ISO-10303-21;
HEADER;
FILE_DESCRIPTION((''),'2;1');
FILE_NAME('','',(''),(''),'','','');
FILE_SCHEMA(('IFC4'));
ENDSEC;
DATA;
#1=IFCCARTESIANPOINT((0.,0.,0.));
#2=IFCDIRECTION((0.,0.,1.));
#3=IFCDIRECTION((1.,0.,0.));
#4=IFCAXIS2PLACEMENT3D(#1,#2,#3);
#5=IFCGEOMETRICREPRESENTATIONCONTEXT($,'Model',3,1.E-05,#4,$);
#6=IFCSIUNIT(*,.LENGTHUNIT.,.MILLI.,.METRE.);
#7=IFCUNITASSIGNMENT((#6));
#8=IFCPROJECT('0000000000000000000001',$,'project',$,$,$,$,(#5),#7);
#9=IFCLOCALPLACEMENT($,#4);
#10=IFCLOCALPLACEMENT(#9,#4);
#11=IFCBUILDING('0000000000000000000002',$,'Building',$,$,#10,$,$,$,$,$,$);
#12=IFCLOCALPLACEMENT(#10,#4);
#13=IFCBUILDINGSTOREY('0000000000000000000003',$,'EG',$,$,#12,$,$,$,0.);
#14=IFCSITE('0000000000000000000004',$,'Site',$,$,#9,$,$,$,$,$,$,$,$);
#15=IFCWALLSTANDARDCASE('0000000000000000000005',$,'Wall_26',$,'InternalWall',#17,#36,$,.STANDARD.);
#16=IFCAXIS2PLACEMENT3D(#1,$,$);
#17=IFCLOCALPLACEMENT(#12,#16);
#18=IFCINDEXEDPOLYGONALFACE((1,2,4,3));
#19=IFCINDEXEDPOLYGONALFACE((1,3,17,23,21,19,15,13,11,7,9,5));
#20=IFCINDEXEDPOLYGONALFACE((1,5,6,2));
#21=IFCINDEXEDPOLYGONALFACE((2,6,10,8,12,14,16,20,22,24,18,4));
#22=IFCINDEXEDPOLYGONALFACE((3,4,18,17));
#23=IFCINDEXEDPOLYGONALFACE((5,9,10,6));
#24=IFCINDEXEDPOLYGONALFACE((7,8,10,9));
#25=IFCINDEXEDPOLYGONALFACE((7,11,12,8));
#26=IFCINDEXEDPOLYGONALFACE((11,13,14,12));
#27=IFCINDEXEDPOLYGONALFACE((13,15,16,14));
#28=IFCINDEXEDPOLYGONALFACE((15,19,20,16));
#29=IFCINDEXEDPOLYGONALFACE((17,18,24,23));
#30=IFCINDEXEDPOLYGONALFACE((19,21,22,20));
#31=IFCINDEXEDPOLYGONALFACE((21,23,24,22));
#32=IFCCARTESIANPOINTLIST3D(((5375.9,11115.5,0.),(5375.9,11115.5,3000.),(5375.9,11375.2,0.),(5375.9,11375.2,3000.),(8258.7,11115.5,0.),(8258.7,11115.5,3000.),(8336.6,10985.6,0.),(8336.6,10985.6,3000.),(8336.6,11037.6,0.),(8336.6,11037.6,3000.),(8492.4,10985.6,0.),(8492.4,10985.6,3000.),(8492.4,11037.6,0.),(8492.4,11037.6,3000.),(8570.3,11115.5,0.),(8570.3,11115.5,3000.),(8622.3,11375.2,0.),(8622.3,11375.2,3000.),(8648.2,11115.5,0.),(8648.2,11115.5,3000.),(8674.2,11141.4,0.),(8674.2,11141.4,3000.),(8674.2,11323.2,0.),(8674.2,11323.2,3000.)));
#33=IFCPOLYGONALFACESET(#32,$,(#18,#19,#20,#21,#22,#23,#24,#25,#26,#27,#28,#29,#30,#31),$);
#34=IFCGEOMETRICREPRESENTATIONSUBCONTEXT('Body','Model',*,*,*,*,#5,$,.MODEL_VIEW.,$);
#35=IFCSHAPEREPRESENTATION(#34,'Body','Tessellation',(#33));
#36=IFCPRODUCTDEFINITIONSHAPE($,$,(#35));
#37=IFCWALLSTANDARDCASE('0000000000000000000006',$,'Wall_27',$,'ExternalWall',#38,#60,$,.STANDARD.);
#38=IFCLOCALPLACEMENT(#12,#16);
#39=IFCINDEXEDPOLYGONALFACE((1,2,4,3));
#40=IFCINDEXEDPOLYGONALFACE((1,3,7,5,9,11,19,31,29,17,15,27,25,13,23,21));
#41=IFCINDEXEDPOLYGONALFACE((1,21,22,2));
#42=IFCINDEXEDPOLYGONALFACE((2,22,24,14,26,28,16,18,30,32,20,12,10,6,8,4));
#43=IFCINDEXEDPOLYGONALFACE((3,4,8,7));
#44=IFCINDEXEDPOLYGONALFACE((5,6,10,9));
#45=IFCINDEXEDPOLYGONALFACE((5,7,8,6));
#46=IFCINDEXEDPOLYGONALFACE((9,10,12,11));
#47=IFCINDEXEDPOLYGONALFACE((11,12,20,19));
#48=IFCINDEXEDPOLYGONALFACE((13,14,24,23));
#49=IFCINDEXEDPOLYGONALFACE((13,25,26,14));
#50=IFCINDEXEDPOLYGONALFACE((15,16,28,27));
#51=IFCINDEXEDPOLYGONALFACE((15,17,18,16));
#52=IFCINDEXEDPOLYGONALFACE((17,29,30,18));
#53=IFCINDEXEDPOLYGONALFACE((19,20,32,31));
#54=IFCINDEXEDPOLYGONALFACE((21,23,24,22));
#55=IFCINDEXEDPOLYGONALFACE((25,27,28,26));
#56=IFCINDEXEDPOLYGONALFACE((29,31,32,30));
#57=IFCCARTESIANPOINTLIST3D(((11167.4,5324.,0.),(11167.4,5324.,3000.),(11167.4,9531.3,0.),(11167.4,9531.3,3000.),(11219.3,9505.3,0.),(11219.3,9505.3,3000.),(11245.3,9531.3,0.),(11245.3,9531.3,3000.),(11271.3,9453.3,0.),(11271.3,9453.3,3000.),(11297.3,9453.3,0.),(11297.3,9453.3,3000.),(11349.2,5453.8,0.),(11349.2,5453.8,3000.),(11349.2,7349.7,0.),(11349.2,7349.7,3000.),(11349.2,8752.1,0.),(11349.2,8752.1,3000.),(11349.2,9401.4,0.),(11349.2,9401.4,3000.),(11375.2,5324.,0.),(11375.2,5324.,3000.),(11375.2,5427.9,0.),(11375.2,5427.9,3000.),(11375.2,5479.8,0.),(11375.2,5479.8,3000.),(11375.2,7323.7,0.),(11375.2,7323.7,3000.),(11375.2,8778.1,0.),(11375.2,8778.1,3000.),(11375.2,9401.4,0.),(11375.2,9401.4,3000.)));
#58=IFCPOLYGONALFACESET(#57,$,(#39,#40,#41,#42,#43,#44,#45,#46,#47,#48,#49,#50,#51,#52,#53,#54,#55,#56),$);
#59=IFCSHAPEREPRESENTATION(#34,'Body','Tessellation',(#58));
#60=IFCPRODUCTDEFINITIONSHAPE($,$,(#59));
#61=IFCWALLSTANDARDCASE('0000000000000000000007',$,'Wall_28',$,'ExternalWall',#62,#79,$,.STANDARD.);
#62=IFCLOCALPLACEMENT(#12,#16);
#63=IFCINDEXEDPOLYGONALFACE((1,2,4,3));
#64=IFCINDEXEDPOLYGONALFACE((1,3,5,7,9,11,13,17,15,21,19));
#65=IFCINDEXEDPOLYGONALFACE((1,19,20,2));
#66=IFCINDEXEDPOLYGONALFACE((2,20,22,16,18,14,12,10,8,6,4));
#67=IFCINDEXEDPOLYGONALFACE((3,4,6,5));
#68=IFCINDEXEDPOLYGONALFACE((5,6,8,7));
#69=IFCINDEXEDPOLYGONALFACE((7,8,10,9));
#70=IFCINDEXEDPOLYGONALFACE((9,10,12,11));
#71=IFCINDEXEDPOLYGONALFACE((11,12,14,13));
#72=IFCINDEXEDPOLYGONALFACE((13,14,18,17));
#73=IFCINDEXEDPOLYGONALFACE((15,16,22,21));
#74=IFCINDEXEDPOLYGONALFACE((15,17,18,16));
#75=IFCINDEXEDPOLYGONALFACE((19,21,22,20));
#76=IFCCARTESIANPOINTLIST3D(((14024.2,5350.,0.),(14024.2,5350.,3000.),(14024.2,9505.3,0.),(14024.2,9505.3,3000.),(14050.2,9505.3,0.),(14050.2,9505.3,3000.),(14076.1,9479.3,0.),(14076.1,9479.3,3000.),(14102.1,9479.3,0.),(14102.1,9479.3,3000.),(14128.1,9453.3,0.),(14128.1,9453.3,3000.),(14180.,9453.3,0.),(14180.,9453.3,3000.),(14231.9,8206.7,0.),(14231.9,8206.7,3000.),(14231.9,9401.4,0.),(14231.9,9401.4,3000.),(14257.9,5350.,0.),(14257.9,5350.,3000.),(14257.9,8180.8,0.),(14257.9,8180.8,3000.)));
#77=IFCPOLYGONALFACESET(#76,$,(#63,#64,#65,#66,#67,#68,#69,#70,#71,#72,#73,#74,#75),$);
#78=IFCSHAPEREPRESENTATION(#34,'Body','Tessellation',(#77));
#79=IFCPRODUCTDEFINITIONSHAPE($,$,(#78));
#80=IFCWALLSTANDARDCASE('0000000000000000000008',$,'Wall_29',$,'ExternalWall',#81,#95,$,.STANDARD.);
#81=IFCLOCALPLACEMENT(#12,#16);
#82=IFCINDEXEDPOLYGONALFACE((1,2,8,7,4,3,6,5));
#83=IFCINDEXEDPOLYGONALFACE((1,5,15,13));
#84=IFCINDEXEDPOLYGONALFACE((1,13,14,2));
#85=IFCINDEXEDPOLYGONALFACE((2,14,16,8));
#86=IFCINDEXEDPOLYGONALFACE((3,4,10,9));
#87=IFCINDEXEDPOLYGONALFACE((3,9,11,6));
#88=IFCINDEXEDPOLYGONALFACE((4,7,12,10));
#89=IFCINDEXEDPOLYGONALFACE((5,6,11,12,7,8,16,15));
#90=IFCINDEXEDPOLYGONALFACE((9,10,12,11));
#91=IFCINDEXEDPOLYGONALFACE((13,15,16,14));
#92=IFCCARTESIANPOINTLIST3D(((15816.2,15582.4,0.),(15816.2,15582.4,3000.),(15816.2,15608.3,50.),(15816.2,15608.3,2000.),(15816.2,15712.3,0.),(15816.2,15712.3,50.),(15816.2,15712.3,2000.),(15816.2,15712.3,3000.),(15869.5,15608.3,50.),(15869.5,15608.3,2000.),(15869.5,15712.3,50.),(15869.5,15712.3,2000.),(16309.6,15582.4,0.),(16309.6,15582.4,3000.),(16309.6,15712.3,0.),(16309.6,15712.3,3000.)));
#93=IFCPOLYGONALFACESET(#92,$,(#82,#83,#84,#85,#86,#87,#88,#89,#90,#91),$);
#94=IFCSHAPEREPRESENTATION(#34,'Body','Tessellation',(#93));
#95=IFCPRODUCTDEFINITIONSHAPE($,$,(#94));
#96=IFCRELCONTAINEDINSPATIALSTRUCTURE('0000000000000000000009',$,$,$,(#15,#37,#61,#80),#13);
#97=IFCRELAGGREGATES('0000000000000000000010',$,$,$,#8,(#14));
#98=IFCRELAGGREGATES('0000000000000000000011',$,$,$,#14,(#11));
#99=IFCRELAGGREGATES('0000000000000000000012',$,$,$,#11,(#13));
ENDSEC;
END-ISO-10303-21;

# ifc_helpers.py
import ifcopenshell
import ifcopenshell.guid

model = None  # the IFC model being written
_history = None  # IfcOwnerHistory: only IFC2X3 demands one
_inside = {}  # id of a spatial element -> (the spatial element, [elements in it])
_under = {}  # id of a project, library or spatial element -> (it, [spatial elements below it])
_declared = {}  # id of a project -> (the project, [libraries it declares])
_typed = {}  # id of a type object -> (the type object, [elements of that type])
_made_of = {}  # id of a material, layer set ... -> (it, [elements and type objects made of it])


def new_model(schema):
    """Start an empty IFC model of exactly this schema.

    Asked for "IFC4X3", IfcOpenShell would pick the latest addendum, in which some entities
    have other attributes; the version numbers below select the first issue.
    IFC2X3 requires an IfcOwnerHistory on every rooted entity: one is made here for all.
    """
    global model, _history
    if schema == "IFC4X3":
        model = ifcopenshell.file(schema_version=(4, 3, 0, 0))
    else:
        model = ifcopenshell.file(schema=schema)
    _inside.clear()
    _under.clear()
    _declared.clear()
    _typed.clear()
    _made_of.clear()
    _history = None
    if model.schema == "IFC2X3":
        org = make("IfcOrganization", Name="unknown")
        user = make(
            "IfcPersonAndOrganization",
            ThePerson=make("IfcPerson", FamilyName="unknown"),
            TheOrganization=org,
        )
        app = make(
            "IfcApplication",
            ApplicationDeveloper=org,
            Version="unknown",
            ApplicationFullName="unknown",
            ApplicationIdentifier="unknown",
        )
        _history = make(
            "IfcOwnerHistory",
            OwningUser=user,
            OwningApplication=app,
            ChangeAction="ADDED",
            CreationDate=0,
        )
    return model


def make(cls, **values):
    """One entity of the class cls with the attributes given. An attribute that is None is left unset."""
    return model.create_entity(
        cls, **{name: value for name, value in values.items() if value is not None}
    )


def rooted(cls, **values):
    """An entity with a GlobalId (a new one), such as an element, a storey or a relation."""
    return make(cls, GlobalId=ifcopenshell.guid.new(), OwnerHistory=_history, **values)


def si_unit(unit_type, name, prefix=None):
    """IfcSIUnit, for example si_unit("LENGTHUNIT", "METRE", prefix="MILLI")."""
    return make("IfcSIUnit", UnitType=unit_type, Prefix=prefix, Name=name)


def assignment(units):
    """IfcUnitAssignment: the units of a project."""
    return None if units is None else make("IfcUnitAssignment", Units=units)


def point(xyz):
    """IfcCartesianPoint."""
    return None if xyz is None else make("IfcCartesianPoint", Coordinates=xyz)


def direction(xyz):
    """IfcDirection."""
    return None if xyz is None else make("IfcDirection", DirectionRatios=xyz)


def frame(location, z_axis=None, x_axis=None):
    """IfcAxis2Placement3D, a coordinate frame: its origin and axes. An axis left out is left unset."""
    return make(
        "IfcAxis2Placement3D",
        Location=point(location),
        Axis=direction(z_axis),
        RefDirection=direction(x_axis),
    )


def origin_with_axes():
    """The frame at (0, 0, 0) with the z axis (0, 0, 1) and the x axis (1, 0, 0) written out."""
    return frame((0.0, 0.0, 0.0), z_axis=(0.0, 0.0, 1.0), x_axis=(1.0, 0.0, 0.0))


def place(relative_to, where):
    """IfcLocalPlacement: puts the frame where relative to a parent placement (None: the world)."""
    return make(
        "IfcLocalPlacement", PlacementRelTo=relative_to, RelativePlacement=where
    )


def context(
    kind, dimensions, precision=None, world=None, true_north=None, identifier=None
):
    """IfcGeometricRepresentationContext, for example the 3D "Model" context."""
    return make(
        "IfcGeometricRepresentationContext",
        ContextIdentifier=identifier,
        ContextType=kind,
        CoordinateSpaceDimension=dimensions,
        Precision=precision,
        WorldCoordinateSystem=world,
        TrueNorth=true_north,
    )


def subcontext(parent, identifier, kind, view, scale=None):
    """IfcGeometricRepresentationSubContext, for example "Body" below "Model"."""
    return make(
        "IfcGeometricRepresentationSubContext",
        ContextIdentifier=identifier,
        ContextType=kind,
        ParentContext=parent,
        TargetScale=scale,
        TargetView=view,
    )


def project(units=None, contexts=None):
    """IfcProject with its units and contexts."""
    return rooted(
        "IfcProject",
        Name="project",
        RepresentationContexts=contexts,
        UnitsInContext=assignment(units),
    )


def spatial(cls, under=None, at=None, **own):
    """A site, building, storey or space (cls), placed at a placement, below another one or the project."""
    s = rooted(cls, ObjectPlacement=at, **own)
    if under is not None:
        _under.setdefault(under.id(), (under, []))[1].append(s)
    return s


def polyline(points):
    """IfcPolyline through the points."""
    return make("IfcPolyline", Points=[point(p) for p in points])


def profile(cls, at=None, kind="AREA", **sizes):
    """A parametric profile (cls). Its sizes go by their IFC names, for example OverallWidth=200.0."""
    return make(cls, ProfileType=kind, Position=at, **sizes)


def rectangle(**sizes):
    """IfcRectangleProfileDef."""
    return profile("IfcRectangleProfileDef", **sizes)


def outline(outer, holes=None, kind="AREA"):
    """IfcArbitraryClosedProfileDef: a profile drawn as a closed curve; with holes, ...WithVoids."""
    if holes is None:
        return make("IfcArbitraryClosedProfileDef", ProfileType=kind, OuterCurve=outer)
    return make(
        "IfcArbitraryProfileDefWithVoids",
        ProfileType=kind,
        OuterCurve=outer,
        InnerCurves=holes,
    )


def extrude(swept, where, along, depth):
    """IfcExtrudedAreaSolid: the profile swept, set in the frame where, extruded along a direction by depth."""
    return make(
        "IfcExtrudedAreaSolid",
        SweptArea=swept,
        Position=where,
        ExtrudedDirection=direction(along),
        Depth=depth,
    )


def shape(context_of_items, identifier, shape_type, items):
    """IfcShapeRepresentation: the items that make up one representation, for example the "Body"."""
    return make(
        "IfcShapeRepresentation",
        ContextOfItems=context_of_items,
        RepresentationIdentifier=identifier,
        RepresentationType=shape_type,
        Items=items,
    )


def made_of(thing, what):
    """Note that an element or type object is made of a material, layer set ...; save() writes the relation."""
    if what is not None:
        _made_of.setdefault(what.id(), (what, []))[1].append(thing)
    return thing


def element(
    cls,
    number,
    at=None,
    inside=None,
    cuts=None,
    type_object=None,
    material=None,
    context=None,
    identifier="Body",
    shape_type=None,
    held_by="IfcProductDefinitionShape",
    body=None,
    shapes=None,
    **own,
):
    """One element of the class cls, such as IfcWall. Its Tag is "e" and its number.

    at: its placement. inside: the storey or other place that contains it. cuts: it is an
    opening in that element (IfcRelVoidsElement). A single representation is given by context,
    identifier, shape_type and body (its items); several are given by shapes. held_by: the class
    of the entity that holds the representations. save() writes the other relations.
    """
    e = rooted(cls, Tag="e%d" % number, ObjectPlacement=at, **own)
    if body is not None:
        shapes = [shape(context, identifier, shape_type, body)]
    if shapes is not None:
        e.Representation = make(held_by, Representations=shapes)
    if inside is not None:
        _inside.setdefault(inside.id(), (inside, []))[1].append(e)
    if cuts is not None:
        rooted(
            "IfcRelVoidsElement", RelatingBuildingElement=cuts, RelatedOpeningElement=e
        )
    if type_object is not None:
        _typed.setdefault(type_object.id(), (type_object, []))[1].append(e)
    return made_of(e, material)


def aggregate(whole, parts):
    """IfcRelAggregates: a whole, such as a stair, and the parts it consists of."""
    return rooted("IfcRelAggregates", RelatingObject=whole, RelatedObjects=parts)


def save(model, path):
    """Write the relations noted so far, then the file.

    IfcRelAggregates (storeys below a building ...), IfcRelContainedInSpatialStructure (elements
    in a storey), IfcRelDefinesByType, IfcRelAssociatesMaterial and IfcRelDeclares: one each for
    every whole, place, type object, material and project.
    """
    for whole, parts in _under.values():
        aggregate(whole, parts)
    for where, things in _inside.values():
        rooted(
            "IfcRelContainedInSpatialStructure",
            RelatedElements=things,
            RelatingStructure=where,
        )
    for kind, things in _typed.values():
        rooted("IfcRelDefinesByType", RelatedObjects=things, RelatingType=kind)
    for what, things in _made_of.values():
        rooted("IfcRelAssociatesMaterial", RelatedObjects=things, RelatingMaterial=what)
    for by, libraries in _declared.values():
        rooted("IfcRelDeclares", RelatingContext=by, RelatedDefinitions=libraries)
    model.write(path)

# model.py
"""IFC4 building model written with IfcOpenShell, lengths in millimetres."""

from ifc_helpers import new_model, si_unit, frame, origin_with_axes, place, context, subcontext, project, spatial, polyline, rectangle, outline, extrude, element, save


model = new_model("IFC4")

# Units and contexts
model_context = context("Model", 3, precision=1e-05, world=origin_with_axes())
body_context = subcontext(model_context, "Body", "Model", "MODEL_VIEW")
ifc_project = project(units=[si_unit("LENGTHUNIT", "METRE", prefix="MILLI")], contexts=[model_context])

# Site, building, storey
site_placement = place(None, origin_with_axes())
site = spatial("IfcSite", under=ifc_project, at=site_placement, Name="Site")
building_placement = place(site_placement, origin_with_axes())
building = spatial("IfcBuilding", under=site, at=building_placement, Name="Building")
storey_placement = place(building_placement, origin_with_axes())
storey = spatial("IfcBuildingStorey", under=building, at=storey_placement, Name="EG", Elevation=0.0)

# Walls
wall_1_placement = place(storey_placement, origin_with_axes())
element("IfcWallStandardCase", 1, at=wall_1_placement, inside=storey, Name="Wall_26", ObjectType="InternalWall", PredefinedType="STANDARD", context=body_context, shape_type="SweptSolid", body=[
    extrude(outline(polyline([(8336.6, 10985.6, 0.0), (8336.6, 11037.6, 0.0), (8258.7, 11115.5, 0.0), (5375.9, 11115.5, 0.0), (5375.9, 11375.2, 0.0), (8622.3, 11375.2, 0.0), (8674.2, 11323.2, 0.0), (8674.2, 11141.4, 0.0), (8648.2, 11115.5, 0.0), (8570.3, 11115.5, 0.0), (8492.4, 11037.6, 0.0), (8492.4, 10985.6, 0.0), (8336.6, 10985.6, 0.0)])), origin_with_axes(), (0.0, 0.0, 1.0), 3000.0),
])
wall_2_placement = place(storey_placement, origin_with_axes())
element("IfcWallStandardCase", 2, at=wall_2_placement, inside=storey, Name="Wall_27", ObjectType="ExternalWall", PredefinedType="STANDARD", context=body_context, shape_type="SweptSolid", body=[
    extrude(outline(polyline([(11167.4, 5324.0, 0.0), (11167.4, 9531.3, 0.0), (11245.3, 9531.3, 0.0), (11219.3, 9505.3, 0.0), (11271.3, 9453.3, 0.0), (11297.3, 9453.3, 0.0), (11349.2, 9401.4, 0.0), (11375.2, 9401.4, 0.0), (11375.2, 8778.1, 0.0), (11349.2, 8752.1, 0.0), (11349.2, 7349.7, 0.0), (11375.2, 7323.7, 0.0), (11375.2, 5479.8, 0.0), (11349.2, 5453.8, 0.0), (11375.2, 5427.9, 0.0), (11375.2, 5324.0, 0.0), (11167.4, 5324.0, 0.0)])), origin_with_axes(), (0.0, 0.0, 1.0), 3000.0),
])
wall_3_placement = place(storey_placement, origin_with_axes())
element("IfcWallStandardCase", 3, at=wall_3_placement, inside=storey, Name="Wall_28", ObjectType="ExternalWall", PredefinedType="STANDARD", context=body_context, shape_type="SweptSolid", body=[
    extrude(outline(polyline([(14024.2, 5350.0, 0.0), (14024.2, 9505.3, 0.0), (14050.2, 9505.3, 0.0), (14076.1, 9479.3, 0.0), (14102.1, 9479.3, 0.0), (14128.1, 9453.3, 0.0), (14180.0, 9453.3, 0.0), (14231.9, 9401.4, 0.0), (14231.9, 8206.7, 0.0), (14257.9, 8180.8, 0.0), (14257.9, 5350.0, 0.0), (14024.2, 5350.0, 0.0)])), origin_with_axes(), (0.0, 0.0, 1.0), 3000.0),
])

# Wall, opening
wall_4_placement = place(storey_placement, origin_with_axes())
wall_4 = element("IfcWallStandardCase", 4, at=wall_4_placement, inside=storey, Name="Wall_29", ObjectType="ExternalWall", PredefinedType="STANDARD", context=body_context, shape_type="SweptSolid", body=[
    extrude(outline(polyline([(15816.2, 15582.4, 0.0), (15816.2, 15712.3, 0.0), (16309.6, 15712.3, 0.0), (16309.6, 15582.4, 0.0), (15816.2, 15582.4, 0.0)])), origin_with_axes(), (0.0, 0.0, 1.0), 3000.0),
])
opening_1_placement = place(wall_4_placement, origin_with_axes())
element("IfcOpeningElement", 5, at=opening_1_placement, inside=storey, cuts=wall_4, context=body_context, shape_type="SweptSolid", body=[
    extrude(rectangle(XDim=1200.0, YDim=129.9), frame((15269.5, 15673.2, 50.0), z_axis=(0.0, 0.0, 1.0), x_axis=(1.0, 0.0, 0.0)), (0.0, 0.0, 1.0), 1950.0),
])

save(model, "model.ifc")
